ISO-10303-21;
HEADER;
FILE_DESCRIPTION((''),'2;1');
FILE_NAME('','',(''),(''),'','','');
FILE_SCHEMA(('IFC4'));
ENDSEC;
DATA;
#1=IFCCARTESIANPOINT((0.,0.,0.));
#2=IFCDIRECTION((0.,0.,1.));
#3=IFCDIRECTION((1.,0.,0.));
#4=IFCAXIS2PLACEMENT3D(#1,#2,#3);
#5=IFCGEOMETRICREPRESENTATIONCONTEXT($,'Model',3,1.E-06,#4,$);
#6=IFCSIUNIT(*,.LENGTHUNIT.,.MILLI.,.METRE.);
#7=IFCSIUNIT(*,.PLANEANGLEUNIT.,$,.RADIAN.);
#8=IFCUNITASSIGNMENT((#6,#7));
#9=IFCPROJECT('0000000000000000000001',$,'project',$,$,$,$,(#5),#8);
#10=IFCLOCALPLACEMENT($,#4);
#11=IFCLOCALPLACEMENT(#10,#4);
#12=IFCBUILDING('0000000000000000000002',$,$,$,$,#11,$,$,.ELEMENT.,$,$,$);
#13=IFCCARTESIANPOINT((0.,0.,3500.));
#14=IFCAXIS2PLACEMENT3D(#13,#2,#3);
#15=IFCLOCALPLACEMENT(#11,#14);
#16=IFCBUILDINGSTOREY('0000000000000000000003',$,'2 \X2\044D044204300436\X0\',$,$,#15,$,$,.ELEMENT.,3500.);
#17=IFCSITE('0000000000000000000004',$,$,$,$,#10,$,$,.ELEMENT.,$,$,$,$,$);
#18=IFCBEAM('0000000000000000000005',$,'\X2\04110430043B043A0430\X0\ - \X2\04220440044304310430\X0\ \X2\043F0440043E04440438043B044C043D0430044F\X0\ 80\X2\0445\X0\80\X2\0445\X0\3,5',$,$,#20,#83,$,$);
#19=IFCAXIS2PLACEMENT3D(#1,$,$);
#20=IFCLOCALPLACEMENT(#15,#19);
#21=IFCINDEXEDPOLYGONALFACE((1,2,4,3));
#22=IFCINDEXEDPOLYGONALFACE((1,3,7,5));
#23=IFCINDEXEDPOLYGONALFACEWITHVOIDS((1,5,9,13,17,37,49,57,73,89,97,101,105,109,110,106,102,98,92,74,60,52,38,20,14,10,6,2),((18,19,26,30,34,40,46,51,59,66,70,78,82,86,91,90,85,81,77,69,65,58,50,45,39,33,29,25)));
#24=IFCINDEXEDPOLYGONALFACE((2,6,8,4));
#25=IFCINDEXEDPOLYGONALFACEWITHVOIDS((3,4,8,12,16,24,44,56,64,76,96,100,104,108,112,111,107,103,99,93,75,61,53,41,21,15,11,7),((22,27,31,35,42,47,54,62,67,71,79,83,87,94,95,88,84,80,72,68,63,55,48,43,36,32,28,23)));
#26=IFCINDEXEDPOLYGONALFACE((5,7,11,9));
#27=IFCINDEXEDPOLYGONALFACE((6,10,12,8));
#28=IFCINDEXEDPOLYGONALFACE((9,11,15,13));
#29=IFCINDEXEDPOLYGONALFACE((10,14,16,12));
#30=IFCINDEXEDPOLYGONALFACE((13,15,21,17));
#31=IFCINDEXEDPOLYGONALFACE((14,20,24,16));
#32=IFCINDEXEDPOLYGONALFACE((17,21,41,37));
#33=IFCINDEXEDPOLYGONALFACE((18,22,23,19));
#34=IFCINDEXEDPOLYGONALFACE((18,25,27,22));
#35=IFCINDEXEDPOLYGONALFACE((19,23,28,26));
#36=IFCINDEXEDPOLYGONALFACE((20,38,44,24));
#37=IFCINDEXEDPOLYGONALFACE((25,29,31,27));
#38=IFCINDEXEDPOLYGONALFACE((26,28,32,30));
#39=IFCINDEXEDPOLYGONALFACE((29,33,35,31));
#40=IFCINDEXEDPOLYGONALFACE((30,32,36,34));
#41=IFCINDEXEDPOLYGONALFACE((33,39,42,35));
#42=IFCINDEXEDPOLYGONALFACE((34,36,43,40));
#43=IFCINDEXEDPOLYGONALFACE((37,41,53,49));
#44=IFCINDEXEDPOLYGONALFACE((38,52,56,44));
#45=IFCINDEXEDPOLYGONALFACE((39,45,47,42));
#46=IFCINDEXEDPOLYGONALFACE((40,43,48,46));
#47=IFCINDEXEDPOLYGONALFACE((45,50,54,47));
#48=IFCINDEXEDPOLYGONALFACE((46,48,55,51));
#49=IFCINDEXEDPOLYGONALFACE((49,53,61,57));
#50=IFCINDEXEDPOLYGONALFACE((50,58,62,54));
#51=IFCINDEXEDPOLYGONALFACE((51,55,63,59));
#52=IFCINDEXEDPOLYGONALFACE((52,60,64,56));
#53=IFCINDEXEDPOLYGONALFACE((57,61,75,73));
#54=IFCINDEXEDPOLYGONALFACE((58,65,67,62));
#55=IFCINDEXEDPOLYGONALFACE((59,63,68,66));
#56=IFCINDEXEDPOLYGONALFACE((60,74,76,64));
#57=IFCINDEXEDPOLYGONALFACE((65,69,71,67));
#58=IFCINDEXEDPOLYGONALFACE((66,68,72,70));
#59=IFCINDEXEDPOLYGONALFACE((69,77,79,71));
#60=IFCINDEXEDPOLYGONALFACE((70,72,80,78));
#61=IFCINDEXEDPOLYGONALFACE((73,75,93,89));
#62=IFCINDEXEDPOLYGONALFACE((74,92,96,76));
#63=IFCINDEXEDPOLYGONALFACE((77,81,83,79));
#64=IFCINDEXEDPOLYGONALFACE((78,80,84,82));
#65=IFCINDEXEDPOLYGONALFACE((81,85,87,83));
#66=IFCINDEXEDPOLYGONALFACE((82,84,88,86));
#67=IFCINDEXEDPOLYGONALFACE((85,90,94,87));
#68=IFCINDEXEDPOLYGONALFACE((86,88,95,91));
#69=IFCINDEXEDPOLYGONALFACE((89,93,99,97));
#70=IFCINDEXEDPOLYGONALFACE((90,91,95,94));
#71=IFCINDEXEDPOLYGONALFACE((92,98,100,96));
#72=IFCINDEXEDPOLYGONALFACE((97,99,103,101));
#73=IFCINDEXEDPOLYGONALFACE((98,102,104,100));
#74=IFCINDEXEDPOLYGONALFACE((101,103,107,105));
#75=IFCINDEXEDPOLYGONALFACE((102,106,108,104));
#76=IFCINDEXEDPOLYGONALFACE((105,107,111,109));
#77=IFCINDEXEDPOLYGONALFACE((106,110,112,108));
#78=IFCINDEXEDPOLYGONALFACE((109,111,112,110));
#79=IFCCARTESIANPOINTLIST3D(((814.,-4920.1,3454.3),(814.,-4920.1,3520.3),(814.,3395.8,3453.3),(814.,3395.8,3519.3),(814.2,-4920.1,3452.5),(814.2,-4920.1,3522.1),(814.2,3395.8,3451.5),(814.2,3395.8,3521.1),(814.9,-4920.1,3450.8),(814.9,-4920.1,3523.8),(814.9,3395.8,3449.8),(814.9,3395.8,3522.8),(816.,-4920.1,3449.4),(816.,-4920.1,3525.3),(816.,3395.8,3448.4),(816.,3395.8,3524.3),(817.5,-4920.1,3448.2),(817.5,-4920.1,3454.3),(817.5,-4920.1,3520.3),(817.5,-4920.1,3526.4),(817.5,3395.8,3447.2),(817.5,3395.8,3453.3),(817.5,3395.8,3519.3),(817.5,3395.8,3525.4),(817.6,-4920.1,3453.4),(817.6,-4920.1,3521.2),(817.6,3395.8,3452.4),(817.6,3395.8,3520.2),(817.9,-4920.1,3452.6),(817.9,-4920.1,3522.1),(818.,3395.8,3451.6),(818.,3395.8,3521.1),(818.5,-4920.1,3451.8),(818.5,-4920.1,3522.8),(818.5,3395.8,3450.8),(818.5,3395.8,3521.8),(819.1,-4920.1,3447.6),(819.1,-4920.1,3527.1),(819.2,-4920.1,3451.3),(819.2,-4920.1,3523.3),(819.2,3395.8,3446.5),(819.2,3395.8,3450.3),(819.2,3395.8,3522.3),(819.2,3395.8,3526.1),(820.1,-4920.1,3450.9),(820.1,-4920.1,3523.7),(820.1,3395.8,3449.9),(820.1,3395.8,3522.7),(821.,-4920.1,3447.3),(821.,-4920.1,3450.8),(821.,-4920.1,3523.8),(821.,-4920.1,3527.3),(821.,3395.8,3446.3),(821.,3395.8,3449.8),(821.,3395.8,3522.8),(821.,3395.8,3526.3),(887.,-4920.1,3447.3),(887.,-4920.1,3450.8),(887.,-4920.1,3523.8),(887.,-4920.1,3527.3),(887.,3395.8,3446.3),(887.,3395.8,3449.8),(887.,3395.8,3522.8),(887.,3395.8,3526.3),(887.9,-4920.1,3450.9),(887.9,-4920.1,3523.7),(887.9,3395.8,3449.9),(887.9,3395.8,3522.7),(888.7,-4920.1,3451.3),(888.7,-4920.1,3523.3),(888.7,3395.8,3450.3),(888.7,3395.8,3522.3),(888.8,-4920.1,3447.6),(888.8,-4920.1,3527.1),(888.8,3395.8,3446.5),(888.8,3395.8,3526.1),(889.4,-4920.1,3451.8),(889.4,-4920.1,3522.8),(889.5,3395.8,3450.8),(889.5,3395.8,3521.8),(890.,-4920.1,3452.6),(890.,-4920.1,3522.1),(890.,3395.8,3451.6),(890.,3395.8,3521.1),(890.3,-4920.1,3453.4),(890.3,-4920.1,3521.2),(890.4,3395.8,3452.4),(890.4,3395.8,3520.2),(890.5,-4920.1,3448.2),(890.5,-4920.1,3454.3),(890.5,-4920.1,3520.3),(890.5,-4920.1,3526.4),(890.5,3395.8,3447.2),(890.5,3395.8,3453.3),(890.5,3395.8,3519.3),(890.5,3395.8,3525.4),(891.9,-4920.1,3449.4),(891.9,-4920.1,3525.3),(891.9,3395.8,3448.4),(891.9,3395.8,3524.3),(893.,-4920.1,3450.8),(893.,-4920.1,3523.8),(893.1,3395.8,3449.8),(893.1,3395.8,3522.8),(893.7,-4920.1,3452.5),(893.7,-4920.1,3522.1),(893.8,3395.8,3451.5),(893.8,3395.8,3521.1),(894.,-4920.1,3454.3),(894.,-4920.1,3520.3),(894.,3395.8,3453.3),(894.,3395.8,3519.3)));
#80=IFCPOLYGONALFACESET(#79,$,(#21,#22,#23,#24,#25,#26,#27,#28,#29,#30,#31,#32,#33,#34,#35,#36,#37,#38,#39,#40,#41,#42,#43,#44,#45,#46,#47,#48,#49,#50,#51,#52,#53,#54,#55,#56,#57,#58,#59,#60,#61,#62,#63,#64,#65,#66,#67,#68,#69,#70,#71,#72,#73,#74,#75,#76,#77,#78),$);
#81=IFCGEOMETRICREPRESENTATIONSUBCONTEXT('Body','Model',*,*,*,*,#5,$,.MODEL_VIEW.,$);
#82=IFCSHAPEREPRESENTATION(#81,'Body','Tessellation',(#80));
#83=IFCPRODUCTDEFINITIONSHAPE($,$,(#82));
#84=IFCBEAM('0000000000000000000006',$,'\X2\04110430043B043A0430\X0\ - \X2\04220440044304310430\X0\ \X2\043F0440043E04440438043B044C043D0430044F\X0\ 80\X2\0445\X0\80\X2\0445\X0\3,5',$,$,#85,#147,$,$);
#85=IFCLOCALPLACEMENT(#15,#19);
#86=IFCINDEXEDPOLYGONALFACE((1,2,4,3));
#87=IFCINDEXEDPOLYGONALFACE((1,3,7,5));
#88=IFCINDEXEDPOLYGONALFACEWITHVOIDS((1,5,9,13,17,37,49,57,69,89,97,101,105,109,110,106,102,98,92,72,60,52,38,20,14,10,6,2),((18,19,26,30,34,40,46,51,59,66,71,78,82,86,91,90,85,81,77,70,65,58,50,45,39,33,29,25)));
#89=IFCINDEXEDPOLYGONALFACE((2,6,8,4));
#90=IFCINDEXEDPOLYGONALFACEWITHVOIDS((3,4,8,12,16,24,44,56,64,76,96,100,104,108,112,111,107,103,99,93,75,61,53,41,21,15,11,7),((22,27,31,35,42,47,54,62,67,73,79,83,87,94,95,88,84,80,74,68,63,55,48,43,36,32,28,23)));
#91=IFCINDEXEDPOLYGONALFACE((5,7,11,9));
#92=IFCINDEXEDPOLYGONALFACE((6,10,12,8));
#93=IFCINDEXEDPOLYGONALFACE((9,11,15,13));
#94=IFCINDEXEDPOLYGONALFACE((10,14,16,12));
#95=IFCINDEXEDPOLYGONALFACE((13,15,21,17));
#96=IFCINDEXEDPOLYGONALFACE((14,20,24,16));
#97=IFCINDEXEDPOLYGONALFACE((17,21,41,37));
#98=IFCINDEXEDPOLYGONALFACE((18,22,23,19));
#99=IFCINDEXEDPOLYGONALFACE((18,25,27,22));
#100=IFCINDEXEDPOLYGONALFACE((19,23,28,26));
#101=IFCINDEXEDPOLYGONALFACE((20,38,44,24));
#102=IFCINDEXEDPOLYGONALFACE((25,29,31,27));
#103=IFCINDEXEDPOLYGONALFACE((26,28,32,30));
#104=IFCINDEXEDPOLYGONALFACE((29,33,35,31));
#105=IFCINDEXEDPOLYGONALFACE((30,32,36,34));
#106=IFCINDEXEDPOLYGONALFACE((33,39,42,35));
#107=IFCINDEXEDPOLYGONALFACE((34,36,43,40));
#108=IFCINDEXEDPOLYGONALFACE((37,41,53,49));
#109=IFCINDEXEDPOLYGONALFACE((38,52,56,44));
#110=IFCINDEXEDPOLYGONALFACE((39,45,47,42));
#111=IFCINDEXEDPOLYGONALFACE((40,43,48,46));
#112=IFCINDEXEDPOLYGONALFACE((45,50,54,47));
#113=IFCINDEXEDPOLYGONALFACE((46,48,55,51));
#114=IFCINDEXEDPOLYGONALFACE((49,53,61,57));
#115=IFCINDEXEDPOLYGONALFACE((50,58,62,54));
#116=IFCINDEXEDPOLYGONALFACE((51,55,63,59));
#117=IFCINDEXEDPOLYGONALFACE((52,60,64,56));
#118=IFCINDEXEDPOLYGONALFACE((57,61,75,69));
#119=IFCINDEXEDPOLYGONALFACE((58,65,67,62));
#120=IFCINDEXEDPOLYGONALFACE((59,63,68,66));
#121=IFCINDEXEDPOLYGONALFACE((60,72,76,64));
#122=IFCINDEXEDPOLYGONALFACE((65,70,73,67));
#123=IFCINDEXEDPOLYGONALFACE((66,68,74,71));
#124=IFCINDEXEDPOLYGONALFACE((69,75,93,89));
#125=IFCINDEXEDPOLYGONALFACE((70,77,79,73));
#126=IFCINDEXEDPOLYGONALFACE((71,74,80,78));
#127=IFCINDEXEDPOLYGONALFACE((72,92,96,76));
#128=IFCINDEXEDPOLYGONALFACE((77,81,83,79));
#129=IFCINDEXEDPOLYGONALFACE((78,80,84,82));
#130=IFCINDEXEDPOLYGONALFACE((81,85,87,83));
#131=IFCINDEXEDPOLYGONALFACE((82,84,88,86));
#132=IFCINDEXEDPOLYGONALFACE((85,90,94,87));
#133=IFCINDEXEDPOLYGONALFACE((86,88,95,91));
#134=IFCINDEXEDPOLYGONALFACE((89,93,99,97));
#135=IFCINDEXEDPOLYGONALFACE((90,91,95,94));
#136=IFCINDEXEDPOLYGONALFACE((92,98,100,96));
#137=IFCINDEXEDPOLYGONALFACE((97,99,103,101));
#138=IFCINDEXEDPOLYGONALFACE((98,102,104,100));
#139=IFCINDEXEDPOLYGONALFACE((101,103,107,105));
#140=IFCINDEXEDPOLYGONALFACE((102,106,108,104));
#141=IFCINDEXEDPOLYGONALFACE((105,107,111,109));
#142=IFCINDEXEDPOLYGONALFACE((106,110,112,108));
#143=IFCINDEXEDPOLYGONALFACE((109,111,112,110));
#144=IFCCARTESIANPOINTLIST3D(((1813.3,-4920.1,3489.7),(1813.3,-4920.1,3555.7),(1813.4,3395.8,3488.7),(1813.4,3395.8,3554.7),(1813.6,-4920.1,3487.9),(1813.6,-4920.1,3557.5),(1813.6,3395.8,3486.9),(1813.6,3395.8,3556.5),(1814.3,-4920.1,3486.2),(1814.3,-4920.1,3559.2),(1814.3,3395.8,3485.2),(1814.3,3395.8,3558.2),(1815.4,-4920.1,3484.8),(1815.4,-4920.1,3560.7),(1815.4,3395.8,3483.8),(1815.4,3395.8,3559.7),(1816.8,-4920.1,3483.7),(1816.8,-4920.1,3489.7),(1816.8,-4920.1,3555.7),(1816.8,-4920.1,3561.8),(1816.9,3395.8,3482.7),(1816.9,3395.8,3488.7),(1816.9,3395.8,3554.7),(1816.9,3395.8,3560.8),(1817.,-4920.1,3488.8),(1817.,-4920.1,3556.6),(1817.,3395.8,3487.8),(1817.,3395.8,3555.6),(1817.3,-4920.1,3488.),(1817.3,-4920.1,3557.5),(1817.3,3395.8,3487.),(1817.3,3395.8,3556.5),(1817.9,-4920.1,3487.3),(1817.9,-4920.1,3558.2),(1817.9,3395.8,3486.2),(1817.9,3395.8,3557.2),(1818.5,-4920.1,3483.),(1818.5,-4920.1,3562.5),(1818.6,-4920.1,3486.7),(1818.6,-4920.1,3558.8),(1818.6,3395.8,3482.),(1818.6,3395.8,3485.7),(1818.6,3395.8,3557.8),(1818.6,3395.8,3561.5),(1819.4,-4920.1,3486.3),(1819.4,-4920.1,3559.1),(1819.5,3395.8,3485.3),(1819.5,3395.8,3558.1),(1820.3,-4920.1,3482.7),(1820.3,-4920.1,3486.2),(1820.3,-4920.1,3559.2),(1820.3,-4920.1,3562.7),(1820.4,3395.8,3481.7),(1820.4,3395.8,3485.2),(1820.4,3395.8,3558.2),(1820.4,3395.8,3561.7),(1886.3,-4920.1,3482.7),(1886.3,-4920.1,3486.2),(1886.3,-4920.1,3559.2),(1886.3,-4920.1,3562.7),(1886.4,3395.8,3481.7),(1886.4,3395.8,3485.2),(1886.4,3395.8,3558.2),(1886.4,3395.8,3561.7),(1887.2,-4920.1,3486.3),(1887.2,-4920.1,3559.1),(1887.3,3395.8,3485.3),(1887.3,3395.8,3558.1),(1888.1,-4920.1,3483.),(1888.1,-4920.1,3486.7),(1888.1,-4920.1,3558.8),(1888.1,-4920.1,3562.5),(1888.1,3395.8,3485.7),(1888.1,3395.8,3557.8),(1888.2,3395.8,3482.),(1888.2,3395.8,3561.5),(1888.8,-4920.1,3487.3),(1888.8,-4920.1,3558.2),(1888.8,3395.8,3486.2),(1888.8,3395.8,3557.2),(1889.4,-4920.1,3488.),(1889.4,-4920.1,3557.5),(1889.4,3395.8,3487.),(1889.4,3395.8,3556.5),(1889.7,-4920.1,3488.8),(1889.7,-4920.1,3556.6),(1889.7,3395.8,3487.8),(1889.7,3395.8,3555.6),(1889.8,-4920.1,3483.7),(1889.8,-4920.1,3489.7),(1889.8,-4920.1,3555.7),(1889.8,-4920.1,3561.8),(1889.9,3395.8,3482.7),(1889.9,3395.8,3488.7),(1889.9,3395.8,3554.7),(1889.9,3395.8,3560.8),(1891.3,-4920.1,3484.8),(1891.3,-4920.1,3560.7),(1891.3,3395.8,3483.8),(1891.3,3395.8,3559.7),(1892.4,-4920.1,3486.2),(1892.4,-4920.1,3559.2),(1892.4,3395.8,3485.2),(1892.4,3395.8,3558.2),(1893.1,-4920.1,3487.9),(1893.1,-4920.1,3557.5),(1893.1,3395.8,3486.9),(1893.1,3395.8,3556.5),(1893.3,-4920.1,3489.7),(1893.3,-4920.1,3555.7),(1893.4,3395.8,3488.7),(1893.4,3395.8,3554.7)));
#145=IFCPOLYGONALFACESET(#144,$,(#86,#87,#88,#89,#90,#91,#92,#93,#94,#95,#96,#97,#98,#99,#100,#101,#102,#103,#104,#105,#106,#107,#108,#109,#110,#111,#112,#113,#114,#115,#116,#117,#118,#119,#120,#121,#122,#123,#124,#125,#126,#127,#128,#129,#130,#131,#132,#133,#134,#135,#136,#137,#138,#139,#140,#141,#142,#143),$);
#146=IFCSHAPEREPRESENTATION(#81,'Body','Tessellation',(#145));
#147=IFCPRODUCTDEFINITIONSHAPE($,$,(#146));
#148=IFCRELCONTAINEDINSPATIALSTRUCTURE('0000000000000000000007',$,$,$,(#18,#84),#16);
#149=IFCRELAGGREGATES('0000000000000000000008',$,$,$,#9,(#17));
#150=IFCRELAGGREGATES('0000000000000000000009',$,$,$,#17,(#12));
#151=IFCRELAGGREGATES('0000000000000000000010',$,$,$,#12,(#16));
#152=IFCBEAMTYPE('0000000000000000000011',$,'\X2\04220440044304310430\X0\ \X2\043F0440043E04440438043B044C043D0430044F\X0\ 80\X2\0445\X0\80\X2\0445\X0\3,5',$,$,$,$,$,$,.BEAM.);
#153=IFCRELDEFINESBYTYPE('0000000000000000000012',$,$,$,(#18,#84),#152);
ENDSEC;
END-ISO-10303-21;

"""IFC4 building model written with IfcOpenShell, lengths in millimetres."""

from ifc_helpers import new_model, si_unit, frame, origin_with_axes, place, context, subcontext, project, spatial, line, arc, indexed_curve, outline, extrude, source, transform, mapped, type_object, element, save


model = new_model("IFC4")

# Units and contexts
model_context = context("Model", 3, precision=1e-06, world=origin_with_axes())
body_context = subcontext(model_context, "Body", "Model", "MODEL_VIEW")
ifc_project = project(units=[si_unit("LENGTHUNIT", "METRE", prefix="MILLI"), si_unit("PLANEANGLEUNIT", "RADIAN")], contexts=[model_context])

# Site, building, storey
site_placement = place(None, origin_with_axes())
site = spatial("IfcSite", under=ifc_project, at=site_placement, CompositionType="ELEMENT")
building_placement = place(site_placement, origin_with_axes())
building = spatial("IfcBuilding", under=site, at=building_placement, CompositionType="ELEMENT")
storey_placement = place(building_placement, frame((0.0, 0.0, 3500.0), z_axis=(0.0, 0.0, 1.0), x_axis=(1.0, 0.0, 0.0)))
storey = spatial("IfcBuildingStorey", under=building, at=storey_placement, Name="2 этаж", CompositionType="ELEMENT", Elevation=3500.0)

# Beams
beam_type = type_object("IfcBeamType", Name="Труба профильная 80х80х3,5", PredefinedType="BEAM")
shared_shape_1 = source(origin_with_axes(), body_context, "Body", "SweptSolid", [
    extrude(outline(indexed_curve([(-40.0, -73.0), (-37.9, -77.9), (-33.0, -80.0), (33.0, -80.0), (37.9, -77.9), (40.0, -73.0), (40.0, -7.0), (37.9, -2.1), (33.0, 0.0), (-33.0, 0.0), (-37.9, -2.1), (-40.0, -7.0)], segments=[arc(1, 2, 3), line(3, 4), arc(4, 5, 6), line(6, 7), arc(7, 8, 9), line(9, 10), arc(10, 11, 12), line(12, 1)]), holes=[indexed_curve([(-36.5, -7.0), (-35.5, -4.5), (-33.0, -3.5), (33.0, -3.5), (35.5, -4.5), (36.5, -7.0), (36.5, -73.0), (35.5, -75.5), (33.0, -76.5), (-33.0, -76.5), (-35.5, -75.5), (-36.5, -73.0)], segments=[arc(1, 2, 3), line(3, 4), arc(4, 5, 6), line(6, 7), arc(7, 8, 9), line(9, 10), arc(10, 11, 12), line(12, 1)])]), origin_with_axes(), (0.0, 0.0, -1.0), 8315.9),
])
for number, where, z_axis, x_axis, name in (
    (1, (854.0, 3395.8, 3526.3), (0.000004, 1.0, -0.000121), (-1.0, 0.000004, 0.0), "Балка - Труба профильная 80х80х3,5"),
    (2, (1853.4, 3395.8, 3561.7), (0.000004, 1.0, -0.000121), (-1.0, 0.000004, 0.0), "Балка - Труба профильная 80х80х3,5"),
):
    element("IfcBeam", number, at=place(storey_placement, frame(where, z_axis=z_axis, x_axis=x_axis)), inside=storey, type_object=beam_type, Name=name, context=body_context, shape_type="MappedRepresentation", body=[
        mapped(shared_shape_1, transform((0.0, 0.0, 0.0), x_axis=(1.0, 0.0, 0.0), y_axis=(0.0, 1.0, 0.0), z_axis=(0.0, 0.0, 1.0), scale=1.0)),
    ])

save(model, "model.ifc")
